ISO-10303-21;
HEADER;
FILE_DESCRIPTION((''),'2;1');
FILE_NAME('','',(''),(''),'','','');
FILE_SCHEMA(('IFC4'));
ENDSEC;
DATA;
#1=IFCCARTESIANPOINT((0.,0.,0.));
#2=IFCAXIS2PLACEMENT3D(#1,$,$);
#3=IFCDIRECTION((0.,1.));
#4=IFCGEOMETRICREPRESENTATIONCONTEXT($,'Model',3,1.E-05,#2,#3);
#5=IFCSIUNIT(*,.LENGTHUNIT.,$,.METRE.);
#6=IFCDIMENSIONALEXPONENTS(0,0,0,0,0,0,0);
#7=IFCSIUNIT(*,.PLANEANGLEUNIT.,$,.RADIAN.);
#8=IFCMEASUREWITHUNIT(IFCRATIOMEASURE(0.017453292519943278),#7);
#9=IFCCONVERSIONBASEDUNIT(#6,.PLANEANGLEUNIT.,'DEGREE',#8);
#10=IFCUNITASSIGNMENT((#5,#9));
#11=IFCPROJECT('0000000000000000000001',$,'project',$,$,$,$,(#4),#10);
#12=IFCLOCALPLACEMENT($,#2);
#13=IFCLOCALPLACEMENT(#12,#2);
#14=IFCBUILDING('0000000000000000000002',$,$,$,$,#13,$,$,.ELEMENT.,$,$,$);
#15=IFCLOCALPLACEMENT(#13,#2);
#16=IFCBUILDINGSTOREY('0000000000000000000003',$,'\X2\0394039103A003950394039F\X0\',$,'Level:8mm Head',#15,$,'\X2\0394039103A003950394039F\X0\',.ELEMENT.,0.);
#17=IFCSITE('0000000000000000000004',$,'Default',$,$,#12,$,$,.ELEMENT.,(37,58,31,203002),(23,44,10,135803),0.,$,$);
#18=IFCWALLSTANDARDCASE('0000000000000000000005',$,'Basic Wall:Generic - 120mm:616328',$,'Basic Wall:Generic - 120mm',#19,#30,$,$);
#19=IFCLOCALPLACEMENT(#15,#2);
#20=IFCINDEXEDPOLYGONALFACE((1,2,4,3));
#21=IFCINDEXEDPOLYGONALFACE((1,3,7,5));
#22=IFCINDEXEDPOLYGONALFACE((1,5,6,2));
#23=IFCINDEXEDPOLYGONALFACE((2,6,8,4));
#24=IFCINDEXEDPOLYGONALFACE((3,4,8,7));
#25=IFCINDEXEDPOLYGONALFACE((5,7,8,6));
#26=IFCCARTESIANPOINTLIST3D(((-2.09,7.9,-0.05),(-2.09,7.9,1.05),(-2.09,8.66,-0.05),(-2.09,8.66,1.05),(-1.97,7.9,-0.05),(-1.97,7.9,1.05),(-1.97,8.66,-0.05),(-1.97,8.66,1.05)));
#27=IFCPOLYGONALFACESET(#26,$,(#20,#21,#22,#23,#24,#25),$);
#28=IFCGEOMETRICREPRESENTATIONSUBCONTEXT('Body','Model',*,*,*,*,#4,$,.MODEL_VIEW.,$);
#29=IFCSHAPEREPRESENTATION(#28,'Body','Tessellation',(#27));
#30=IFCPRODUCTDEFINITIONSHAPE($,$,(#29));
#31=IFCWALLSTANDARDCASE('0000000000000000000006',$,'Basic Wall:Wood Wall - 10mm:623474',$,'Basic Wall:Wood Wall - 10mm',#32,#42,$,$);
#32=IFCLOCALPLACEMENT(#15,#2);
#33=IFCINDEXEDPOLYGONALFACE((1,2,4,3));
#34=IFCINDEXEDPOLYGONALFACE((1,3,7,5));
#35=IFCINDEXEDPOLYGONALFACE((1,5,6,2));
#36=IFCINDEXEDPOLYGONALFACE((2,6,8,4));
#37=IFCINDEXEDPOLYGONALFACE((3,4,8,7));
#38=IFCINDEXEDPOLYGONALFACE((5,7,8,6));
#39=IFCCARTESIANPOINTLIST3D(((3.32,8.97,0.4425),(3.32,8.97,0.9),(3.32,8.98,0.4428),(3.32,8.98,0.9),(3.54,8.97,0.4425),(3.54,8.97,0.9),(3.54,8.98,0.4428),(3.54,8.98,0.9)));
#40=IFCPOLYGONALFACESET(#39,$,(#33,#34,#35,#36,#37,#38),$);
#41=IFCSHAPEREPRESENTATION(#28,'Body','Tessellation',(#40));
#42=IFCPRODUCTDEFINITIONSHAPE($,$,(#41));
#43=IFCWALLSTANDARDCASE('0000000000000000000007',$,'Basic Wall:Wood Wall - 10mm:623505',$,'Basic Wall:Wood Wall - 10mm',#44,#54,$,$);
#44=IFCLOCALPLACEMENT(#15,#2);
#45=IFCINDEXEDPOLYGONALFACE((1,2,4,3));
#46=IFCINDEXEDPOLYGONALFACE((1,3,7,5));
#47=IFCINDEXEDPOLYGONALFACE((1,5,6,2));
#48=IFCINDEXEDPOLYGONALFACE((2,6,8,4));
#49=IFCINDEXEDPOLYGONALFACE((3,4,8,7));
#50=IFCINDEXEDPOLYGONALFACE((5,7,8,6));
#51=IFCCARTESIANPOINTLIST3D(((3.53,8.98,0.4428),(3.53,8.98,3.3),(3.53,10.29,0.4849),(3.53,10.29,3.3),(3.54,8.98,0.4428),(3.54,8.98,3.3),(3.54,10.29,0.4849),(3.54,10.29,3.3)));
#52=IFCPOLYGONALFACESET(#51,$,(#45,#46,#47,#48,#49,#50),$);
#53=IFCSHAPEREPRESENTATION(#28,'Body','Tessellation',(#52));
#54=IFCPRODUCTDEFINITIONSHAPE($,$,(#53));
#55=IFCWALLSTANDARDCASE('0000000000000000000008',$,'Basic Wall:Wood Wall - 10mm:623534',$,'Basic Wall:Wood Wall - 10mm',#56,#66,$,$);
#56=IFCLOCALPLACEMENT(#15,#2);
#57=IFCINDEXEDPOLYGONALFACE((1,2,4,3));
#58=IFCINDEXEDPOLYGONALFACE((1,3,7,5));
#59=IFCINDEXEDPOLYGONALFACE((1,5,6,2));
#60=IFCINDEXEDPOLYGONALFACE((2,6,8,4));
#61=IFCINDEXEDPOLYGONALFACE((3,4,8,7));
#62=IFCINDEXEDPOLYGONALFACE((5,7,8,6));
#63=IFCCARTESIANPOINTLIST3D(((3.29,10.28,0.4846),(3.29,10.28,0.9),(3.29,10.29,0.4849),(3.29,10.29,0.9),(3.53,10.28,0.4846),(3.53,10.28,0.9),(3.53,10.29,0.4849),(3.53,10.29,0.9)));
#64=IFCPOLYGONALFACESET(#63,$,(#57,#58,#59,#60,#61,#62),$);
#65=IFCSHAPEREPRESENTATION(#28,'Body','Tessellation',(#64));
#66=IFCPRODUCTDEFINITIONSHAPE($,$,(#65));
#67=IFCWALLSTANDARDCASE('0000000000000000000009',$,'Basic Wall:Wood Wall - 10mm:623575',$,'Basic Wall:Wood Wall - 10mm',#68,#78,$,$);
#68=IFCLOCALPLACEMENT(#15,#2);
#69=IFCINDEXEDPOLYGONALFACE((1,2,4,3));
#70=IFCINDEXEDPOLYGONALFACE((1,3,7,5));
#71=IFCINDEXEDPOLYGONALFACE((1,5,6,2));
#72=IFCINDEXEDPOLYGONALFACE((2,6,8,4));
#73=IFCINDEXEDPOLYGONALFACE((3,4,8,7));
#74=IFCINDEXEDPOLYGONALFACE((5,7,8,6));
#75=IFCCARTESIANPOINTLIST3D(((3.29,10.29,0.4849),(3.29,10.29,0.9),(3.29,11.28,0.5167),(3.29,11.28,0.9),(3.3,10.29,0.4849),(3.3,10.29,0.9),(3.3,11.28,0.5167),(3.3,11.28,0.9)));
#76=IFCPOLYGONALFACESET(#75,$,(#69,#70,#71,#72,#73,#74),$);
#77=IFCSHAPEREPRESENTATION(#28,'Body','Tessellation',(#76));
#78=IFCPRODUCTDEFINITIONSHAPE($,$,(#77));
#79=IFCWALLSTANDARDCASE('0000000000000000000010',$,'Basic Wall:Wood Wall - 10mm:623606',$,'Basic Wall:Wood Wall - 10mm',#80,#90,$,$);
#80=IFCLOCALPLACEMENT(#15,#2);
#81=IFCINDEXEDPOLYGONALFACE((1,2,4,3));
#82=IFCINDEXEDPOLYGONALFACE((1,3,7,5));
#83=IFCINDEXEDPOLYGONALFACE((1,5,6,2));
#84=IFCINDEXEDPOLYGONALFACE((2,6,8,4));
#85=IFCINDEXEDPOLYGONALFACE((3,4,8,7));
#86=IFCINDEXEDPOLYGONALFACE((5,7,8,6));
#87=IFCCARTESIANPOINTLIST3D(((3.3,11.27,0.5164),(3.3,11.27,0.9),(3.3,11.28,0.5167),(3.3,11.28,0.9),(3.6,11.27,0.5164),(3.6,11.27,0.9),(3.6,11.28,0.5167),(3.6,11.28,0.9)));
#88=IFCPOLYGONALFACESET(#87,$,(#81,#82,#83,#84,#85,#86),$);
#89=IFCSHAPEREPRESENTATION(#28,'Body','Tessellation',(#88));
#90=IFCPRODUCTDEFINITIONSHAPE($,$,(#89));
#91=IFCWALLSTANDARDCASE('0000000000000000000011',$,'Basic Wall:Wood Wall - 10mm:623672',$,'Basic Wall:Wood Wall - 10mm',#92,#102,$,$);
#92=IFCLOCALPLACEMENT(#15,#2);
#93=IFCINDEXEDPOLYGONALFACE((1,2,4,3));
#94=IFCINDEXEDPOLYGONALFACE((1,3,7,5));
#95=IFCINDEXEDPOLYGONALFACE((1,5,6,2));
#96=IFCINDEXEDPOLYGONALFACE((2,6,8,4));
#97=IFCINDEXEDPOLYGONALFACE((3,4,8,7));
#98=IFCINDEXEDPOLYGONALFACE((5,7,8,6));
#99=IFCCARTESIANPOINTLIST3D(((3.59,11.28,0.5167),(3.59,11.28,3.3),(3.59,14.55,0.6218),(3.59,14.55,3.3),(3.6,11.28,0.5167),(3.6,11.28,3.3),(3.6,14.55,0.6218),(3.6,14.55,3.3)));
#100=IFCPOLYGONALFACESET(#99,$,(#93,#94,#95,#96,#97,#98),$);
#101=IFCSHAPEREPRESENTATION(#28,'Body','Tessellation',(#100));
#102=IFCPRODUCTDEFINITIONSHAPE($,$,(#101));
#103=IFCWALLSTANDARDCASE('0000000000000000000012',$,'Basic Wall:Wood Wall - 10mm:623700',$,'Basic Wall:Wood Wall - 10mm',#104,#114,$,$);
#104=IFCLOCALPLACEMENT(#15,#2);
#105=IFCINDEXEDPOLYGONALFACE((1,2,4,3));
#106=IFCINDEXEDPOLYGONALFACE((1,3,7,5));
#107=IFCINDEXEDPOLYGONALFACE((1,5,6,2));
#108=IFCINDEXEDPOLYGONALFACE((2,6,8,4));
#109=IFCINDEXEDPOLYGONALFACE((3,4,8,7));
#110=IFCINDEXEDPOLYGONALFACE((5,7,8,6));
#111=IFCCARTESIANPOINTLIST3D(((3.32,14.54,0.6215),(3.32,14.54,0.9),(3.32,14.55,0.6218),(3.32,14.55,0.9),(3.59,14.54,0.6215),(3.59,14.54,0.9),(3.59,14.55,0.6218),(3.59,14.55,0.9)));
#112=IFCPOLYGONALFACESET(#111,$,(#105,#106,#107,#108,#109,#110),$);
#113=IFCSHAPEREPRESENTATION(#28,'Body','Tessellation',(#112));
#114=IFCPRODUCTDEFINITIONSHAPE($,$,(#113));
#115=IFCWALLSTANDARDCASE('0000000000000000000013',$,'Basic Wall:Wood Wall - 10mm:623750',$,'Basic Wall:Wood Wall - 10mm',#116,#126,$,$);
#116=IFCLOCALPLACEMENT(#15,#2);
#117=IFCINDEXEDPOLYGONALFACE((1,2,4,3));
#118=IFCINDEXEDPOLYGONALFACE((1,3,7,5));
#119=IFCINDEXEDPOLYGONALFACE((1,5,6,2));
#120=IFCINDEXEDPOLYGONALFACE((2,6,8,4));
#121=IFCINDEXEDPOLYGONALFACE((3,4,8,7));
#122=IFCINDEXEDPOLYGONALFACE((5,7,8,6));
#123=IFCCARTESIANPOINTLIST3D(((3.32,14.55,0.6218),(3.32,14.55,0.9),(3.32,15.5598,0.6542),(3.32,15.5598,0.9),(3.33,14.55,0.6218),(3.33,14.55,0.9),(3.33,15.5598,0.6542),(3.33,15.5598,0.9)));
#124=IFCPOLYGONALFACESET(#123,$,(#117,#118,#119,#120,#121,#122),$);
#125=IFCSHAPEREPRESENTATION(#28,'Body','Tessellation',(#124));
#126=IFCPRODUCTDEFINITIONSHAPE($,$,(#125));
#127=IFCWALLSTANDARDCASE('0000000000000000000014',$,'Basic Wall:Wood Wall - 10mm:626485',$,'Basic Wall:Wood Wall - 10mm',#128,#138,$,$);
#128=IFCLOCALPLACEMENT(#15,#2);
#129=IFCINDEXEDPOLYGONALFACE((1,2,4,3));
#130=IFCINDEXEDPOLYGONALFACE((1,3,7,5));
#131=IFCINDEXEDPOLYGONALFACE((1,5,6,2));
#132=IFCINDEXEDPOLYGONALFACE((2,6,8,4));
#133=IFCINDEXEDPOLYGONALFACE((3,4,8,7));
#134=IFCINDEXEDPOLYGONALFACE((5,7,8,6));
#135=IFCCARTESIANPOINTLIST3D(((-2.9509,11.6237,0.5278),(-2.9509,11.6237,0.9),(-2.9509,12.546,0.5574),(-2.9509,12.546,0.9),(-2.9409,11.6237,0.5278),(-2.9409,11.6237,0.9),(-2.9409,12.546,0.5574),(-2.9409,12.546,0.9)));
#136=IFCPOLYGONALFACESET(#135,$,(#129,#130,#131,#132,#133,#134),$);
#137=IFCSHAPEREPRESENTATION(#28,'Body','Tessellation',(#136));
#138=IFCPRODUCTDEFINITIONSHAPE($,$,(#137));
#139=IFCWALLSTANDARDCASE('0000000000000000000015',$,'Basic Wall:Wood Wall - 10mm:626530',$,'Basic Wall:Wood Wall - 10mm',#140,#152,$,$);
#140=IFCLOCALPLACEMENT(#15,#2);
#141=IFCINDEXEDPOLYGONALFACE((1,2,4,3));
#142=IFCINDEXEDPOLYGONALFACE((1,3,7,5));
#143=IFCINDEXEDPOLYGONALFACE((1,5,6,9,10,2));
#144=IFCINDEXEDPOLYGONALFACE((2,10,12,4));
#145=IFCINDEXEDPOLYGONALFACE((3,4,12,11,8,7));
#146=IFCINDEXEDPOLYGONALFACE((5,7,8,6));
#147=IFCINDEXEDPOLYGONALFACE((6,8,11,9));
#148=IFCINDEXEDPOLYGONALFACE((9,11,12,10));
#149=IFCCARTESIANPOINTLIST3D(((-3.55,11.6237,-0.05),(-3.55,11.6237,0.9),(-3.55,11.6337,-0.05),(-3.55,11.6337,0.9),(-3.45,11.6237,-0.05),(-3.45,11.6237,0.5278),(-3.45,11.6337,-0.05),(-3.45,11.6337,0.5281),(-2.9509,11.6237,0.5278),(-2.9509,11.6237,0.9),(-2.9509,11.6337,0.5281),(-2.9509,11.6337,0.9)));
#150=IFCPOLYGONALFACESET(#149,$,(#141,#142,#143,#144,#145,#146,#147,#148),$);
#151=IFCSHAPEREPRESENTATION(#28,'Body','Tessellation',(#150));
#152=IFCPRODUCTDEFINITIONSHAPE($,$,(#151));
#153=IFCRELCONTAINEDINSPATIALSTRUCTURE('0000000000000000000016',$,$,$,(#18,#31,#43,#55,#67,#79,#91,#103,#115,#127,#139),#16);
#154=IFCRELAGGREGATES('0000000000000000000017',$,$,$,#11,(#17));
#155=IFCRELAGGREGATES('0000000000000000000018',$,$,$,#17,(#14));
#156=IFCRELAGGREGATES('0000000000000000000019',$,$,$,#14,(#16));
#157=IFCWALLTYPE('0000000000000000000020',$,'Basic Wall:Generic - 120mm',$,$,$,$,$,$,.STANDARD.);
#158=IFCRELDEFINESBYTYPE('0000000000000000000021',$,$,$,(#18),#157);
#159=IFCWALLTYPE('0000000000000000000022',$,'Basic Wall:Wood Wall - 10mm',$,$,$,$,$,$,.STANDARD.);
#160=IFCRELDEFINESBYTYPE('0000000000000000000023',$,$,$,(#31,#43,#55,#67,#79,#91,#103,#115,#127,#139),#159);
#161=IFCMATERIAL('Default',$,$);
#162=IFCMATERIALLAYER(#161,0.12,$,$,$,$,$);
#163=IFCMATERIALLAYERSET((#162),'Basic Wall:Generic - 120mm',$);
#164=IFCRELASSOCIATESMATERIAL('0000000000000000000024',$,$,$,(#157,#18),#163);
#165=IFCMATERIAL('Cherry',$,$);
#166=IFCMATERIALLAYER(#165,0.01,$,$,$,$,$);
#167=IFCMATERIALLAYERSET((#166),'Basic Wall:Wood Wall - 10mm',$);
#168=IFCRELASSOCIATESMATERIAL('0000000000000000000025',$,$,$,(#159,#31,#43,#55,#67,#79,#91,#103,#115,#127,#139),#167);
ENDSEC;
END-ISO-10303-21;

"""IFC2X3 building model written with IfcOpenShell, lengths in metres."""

from ifc_helpers import new_model, entity, si_unit, converted_unit, direction, frame, frame_2d, origin, place, context, subcontext, project, spatial, polyline, rectangle, extrude, clip, bounded_halfspace, material, layer, layer_set, layer_usage, type_object, element, save


model = new_model("IFC2X3")

# Units and contexts
model_context = context("Model", 3, precision=1e-05, world=origin(), true_north=direction((0.0, 1.0)))
body_context = subcontext(model_context, "Body", "Model", "MODEL_VIEW")
ifc_project = project(units=[si_unit("LENGTHUNIT", "METRE"), converted_unit("PLANEANGLEUNIT", "DEGREE", entity("IfcRatioMeasure", 0.017453292519943278), si_unit("PLANEANGLEUNIT", "RADIAN"), dimensions=[0, 0, 0, 0, 0, 0, 0])], contexts=[model_context])

# Site, building, storey
site_placement = place(None, origin())
site = spatial("IfcSite", under=ifc_project, at=site_placement, Name="Default", CompositionType="ELEMENT", RefLatitude=(37, 58, 31, 203002), RefLongitude=(23, 44, 10, 135803), RefElevation=0.0)
building_placement = place(site_placement, origin())
building = spatial("IfcBuilding", under=site, at=building_placement, CompositionType="ELEMENT")
storey_placement = place(building_placement, origin())
storey = spatial("IfcBuildingStorey", under=building, at=storey_placement, Name="ΔΑΠΕΔΟ", ObjectType="Level:8mm Head", LongName="ΔΑΠΕΔΟ", CompositionType="ELEMENT", Elevation=0.0)

# Walls
ifc_material_1 = material(Name="Default")
ifc_layer_1 = layer(ifc_material_1, 0.12)
ifc_layer_set_1 = layer_set([ifc_layer_1], Name="Basic Wall:Generic - 120mm")
ifc_layer_usage_1 = layer_usage(ifc_layer_set_1, "AXIS2", "POSITIVE", -0.06)
wall_type_1 = type_object("IfcWallType", Name="Basic Wall:Generic - 120mm", PredefinedType="STANDARD", material=ifc_layer_set_1)
wall_1_placement = place(storey_placement, frame((-2.03, 8.66, -0.05), z_axis=(0.0, 0.0, 1.0), x_axis=(0.0, -1.0, 0.0)))
element("IfcWallStandardCase", 1, at=wall_1_placement, inside=storey, type_object=wall_type_1, material=ifc_layer_usage_1, Name="Basic Wall:Generic - 120mm:616328", ObjectType="Basic Wall:Generic - 120mm", context=body_context, shape_type="SweptSolid", body=[
    extrude(rectangle(XDim=0.76, YDim=0.12, at=frame_2d((0.38, 0.0), x_axis=(-1.0, 0.0))), origin(), (0.0, 0.0, 1.0), 1.1),
])
ifc_material_2 = material(Name="Cherry")
ifc_layer_2 = layer(ifc_material_2, 0.01)
ifc_layer_set_2 = layer_set([ifc_layer_2], Name="Basic Wall:Wood Wall - 10mm")
ifc_layer_usage_2 = layer_usage(ifc_layer_set_2, "AXIS2", "NEGATIVE", 0.005)
wall_type_2 = type_object("IfcWallType", Name="Basic Wall:Wood Wall - 10mm", PredefinedType="STANDARD", material=ifc_layer_set_2)
wall_2_placement = place(storey_placement, frame((3.32, 8.975, 0.4425)))
element("IfcWallStandardCase", 2, at=wall_2_placement, inside=storey, type_object=wall_type_2, material=ifc_layer_usage_2, Name="Basic Wall:Wood Wall - 10mm:623474", ObjectType="Basic Wall:Wood Wall - 10mm", context=body_context, shape_type="Clipping", body=[
    clip(extrude(rectangle(XDim=0.22, YDim=0.01, at=frame_2d((0.11, 0.0), x_axis=(-1.0, 0.0))), origin(), (0.0, 0.0, 1.0), 0.4575), bounded_halfspace(frame((0.22, -0.005, 0.0), z_axis=(0.0, -0.032108, 0.999484), x_axis=(1.0, 0.0, 0.0)), True, frame((0.22, -0.005, 0.0)), polyline([(0.0, 0.0), (0.0, 0.01), (-0.01, 0.01), (-0.22, 0.01), (-0.22, 0.0), (0.0, 0.0)]))),
])
wall_3_placement = place(storey_placement, frame((3.535, 8.98, 0.4428), z_axis=(0.0, 0.0, 1.0), x_axis=(0.0, 1.0, 0.0)))
element("IfcWallStandardCase", 3, at=wall_3_placement, inside=storey, type_object=wall_type_2, material=ifc_layer_usage_2, Name="Basic Wall:Wood Wall - 10mm:623505", ObjectType="Basic Wall:Wood Wall - 10mm", context=body_context, shape_type="Clipping", body=[
    clip(extrude(rectangle(XDim=1.31, YDim=0.01, at=frame_2d((0.655, 0.0), x_axis=(-1.0, 0.0))), origin(), (0.0, 0.0, 1.0), 2.8572), bounded_halfspace(frame((1.31, -0.005, 0.0421), z_axis=(-0.032108, 0.0, 0.999484), x_axis=(0.0, -1.0, 0.0)), True, frame((1.31, -0.005, 0.0421)), polyline([(0.0, 0.0), (0.0, 0.01), (-0.01, 0.01), (-1.31, 0.01), (-1.31, 0.0), (0.0, 0.0)]))),
])
wall_4_placement = place(storey_placement, frame((3.53, 10.285, 0.4846), z_axis=(0.0, 0.0, 1.0), x_axis=(-1.0, 0.0, 0.0)))
element("IfcWallStandardCase", 4, at=wall_4_placement, inside=storey, type_object=wall_type_2, material=ifc_layer_usage_2, Name="Basic Wall:Wood Wall - 10mm:623534", ObjectType="Basic Wall:Wood Wall - 10mm", context=body_context, shape_type="Clipping", body=[
    clip(extrude(rectangle(XDim=0.24, YDim=0.01, at=frame_2d((0.12, 0.0), x_axis=(-1.0, 0.0))), origin(), (0.0, 0.0, 1.0), 0.4154), bounded_halfspace(frame((0.24, -0.005, 0.0003), z_axis=(0.0, 0.032108, 0.999484), x_axis=(-1.0, 0.0, 0.0)), True, frame((0.24, -0.005, 0.0003)), polyline([(0.0, 0.0), (0.0, 0.01), (-0.24, 0.01), (-0.24, 0.0), (-0.06, 0.0), (-0.01, 0.0), (0.0, 0.0)]))),
])
wall_5_placement = place(storey_placement, frame((3.295, 10.29, 0.4849), z_axis=(0.0, 0.0, 1.0), x_axis=(0.0, 1.0, 0.0)))
element("IfcWallStandardCase", 5, at=wall_5_placement, inside=storey, type_object=wall_type_2, material=ifc_layer_usage_2, Name="Basic Wall:Wood Wall - 10mm:623575", ObjectType="Basic Wall:Wood Wall - 10mm", context=body_context, shape_type="Clipping", body=[
    clip(extrude(rectangle(XDim=0.99, YDim=0.01, at=frame_2d((0.495, 0.0), x_axis=(-1.0, 0.0))), origin(), (0.0, 0.0, 1.0), 0.4151), bounded_halfspace(frame((0.99, -0.005, 0.0318), z_axis=(-0.032108, 0.0, 0.999484), x_axis=(0.0, -1.0, 0.0)), True, frame((0.99, -0.005, 0.0318)), polyline([(0.0, 0.0), (0.0, 0.01), (-0.99, 0.01), (-0.99, 0.0), (-0.06, 0.0), (-0.01, 0.0), (0.0, 0.0)]))),
])
wall_6_placement = place(storey_placement, frame((3.3, 11.275, 0.5164)))
element("IfcWallStandardCase", 6, at=wall_6_placement, inside=storey, type_object=wall_type_2, material=ifc_layer_usage_2, Name="Basic Wall:Wood Wall - 10mm:623606", ObjectType="Basic Wall:Wood Wall - 10mm", context=body_context, shape_type="Clipping", body=[
    clip(extrude(rectangle(XDim=0.3, YDim=0.01, at=frame_2d((0.15, 0.0), x_axis=(-1.0, 0.0))), origin(), (0.0, 0.0, 1.0), 0.3836), bounded_halfspace(frame((0.3, -0.005, 0.0), z_axis=(0.0, -0.032108, 0.999484), x_axis=(1.0, 0.0, 0.0)), True, frame((0.3, -0.005, 0.0)), polyline([(0.0, 0.0), (0.0, 0.01), (-0.01, 0.01), (-0.3, 0.01), (-0.3, 0.0), (0.0, 0.0)]))),
])
wall_7_placement = place(storey_placement, frame((3.595, 11.28, 0.5167), z_axis=(0.0, 0.0, 1.0), x_axis=(0.0, 1.0, 0.0)))
element("IfcWallStandardCase", 7, at=wall_7_placement, inside=storey, type_object=wall_type_2, material=ifc_layer_usage_2, Name="Basic Wall:Wood Wall - 10mm:623672", ObjectType="Basic Wall:Wood Wall - 10mm", context=body_context, shape_type="Clipping", body=[
    clip(extrude(rectangle(XDim=3.27, YDim=0.01, at=frame_2d((1.635, 0.0), x_axis=(-1.0, 0.0))), origin(), (0.0, 0.0, 1.0), 2.7833), bounded_halfspace(frame((3.27, -0.005, 0.105), z_axis=(-0.032108, 0.0, 0.999484), x_axis=(0.0, -1.0, 0.0)), True, frame((3.27, -0.005, 0.105)), polyline([(0.0, 0.0), (0.0, 0.01), (-0.01, 0.01), (-3.27, 0.01), (-3.27, 0.0), (0.0, 0.0)]))),
])
wall_8_placement = place(storey_placement, frame((3.59, 14.545, 0.6215), z_axis=(0.0, 0.0, 1.0), x_axis=(-1.0, 0.0, 0.0)))
element("IfcWallStandardCase", 8, at=wall_8_placement, inside=storey, type_object=wall_type_2, material=ifc_layer_usage_2, Name="Basic Wall:Wood Wall - 10mm:623700", ObjectType="Basic Wall:Wood Wall - 10mm", context=body_context, shape_type="Clipping", body=[
    clip(extrude(rectangle(XDim=0.27, YDim=0.01, at=frame_2d((0.135, 0.0), x_axis=(-1.0, 0.0))), origin(), (0.0, 0.0, 1.0), 0.2785), bounded_halfspace(frame((0.27, -0.005, 0.0003), z_axis=(0.0, 0.032108, 0.999484), x_axis=(-1.0, 0.0, 0.0)), True, frame((0.27, -0.005, 0.0003)), polyline([(0.0, 0.0), (0.0, 0.01), (-0.27, 0.01), (-0.27, 0.0), (-0.06, 0.0), (-0.01, 0.0), (0.0, 0.0)]))),
])
wall_9_placement = place(storey_placement, frame((3.325, 14.55, 0.6218), z_axis=(0.0, 0.0, 1.0), x_axis=(0.0, 1.0, 0.0)))
element("IfcWallStandardCase", 9, at=wall_9_placement, inside=storey, type_object=wall_type_2, material=ifc_layer_usage_2, Name="Basic Wall:Wood Wall - 10mm:623750", ObjectType="Basic Wall:Wood Wall - 10mm", context=body_context, shape_type="Clipping", body=[
    clip(extrude(rectangle(XDim=1.0098, YDim=0.01, at=frame_2d((0.5049, 0.0), x_axis=(-1.0, 0.0))), origin(), (0.0, 0.0, 1.0), 0.2782), bounded_halfspace(frame((1.0098, -0.005, 0.0324), z_axis=(-0.032108, 0.0, 0.999484), x_axis=(0.0, -1.0, 0.0)), True, frame((1.0098, -0.005, 0.0324)), polyline([(0.0, 0.0), (0.0, 0.01), (-1.0098, 0.01), (-1.0098, 0.0), (-0.06, 0.0), (-0.01, 0.0), (0.0, 0.0)]))),
])
ifc_layer_usage_3 = layer_usage(ifc_layer_set_2, "AXIS2", "POSITIVE", -0.005)
wall_10_placement = place(storey_placement, frame((-2.9459, 12.546, 0.5278), z_axis=(0.0, 0.0, 1.0), x_axis=(0.0, -1.0, 0.0)))
element("IfcWallStandardCase", 10, at=wall_10_placement, inside=storey, type_object=wall_type_2, material=ifc_layer_usage_3, Name="Basic Wall:Wood Wall - 10mm:626485", ObjectType="Basic Wall:Wood Wall - 10mm", context=body_context, shape_type="Clipping", body=[
    clip(extrude(rectangle(XDim=0.9223, YDim=0.01, at=frame_2d((0.4611, 0.0), x_axis=(-1.0, 0.0))), origin(), (0.0, 0.0, 1.0), 0.3722), bounded_halfspace(frame((0.9223, -0.005, 0.0), z_axis=(0.032108, 0.0, 0.999484), x_axis=(0.0, 1.0, 0.0)), True, frame((0.9223, -0.005, 0.0)), polyline([(0.0, 0.0), (0.0, 0.01), (-0.9223, 0.01), (-0.9223, 0.0), (-0.01, 0.0), (0.0, 0.0)]))),
])
wall_11_placement = place(storey_placement, frame((-2.9509, 11.6287, -0.05), z_axis=(0.0, 0.0, 1.0), x_axis=(-1.0, 0.0, 0.0)))
element("IfcWallStandardCase", 11, at=wall_11_placement, inside=storey, type_object=wall_type_2, material=ifc_layer_usage_3, Name="Basic Wall:Wood Wall - 10mm:626530", ObjectType="Basic Wall:Wood Wall - 10mm", context=body_context, shape_type="Clipping", body=[
    clip(clip(extrude(rectangle(XDim=0.5991, YDim=0.01, at=frame_2d((0.2995, 0.0), x_axis=(-1.0, 0.0))), origin(), (0.0, 0.0, 1.0), 0.95), bounded_halfspace(frame((0.0, -0.005, 0.5781), z_axis=(0.0, 0.032108, 0.999484), x_axis=(-1.0, 0.0, 0.0)), True, frame((0.0, -0.005, 0.5781)), polyline([(0.0, 0.0), (0.4991, 0.0), (0.4991, 0.01), (0.0, 0.01), (0.0, 0.0)]))), bounded_halfspace(frame((0.5991, -0.005, 0.0), z_axis=(0.0, 0.0, 1.0), x_axis=(0.0, -1.0, 0.0)), True, frame((0.5991, -0.005, 0.0), z_axis=(0.0, 0.0, 1.0), x_axis=(0.0, -1.0, 0.0)), polyline([(0.0, 0.0), (-0.01, 0.0), (-0.01, -0.1), (0.0, -0.1), (0.0, 0.0)]))),
])

save(model, "model.ifc")
